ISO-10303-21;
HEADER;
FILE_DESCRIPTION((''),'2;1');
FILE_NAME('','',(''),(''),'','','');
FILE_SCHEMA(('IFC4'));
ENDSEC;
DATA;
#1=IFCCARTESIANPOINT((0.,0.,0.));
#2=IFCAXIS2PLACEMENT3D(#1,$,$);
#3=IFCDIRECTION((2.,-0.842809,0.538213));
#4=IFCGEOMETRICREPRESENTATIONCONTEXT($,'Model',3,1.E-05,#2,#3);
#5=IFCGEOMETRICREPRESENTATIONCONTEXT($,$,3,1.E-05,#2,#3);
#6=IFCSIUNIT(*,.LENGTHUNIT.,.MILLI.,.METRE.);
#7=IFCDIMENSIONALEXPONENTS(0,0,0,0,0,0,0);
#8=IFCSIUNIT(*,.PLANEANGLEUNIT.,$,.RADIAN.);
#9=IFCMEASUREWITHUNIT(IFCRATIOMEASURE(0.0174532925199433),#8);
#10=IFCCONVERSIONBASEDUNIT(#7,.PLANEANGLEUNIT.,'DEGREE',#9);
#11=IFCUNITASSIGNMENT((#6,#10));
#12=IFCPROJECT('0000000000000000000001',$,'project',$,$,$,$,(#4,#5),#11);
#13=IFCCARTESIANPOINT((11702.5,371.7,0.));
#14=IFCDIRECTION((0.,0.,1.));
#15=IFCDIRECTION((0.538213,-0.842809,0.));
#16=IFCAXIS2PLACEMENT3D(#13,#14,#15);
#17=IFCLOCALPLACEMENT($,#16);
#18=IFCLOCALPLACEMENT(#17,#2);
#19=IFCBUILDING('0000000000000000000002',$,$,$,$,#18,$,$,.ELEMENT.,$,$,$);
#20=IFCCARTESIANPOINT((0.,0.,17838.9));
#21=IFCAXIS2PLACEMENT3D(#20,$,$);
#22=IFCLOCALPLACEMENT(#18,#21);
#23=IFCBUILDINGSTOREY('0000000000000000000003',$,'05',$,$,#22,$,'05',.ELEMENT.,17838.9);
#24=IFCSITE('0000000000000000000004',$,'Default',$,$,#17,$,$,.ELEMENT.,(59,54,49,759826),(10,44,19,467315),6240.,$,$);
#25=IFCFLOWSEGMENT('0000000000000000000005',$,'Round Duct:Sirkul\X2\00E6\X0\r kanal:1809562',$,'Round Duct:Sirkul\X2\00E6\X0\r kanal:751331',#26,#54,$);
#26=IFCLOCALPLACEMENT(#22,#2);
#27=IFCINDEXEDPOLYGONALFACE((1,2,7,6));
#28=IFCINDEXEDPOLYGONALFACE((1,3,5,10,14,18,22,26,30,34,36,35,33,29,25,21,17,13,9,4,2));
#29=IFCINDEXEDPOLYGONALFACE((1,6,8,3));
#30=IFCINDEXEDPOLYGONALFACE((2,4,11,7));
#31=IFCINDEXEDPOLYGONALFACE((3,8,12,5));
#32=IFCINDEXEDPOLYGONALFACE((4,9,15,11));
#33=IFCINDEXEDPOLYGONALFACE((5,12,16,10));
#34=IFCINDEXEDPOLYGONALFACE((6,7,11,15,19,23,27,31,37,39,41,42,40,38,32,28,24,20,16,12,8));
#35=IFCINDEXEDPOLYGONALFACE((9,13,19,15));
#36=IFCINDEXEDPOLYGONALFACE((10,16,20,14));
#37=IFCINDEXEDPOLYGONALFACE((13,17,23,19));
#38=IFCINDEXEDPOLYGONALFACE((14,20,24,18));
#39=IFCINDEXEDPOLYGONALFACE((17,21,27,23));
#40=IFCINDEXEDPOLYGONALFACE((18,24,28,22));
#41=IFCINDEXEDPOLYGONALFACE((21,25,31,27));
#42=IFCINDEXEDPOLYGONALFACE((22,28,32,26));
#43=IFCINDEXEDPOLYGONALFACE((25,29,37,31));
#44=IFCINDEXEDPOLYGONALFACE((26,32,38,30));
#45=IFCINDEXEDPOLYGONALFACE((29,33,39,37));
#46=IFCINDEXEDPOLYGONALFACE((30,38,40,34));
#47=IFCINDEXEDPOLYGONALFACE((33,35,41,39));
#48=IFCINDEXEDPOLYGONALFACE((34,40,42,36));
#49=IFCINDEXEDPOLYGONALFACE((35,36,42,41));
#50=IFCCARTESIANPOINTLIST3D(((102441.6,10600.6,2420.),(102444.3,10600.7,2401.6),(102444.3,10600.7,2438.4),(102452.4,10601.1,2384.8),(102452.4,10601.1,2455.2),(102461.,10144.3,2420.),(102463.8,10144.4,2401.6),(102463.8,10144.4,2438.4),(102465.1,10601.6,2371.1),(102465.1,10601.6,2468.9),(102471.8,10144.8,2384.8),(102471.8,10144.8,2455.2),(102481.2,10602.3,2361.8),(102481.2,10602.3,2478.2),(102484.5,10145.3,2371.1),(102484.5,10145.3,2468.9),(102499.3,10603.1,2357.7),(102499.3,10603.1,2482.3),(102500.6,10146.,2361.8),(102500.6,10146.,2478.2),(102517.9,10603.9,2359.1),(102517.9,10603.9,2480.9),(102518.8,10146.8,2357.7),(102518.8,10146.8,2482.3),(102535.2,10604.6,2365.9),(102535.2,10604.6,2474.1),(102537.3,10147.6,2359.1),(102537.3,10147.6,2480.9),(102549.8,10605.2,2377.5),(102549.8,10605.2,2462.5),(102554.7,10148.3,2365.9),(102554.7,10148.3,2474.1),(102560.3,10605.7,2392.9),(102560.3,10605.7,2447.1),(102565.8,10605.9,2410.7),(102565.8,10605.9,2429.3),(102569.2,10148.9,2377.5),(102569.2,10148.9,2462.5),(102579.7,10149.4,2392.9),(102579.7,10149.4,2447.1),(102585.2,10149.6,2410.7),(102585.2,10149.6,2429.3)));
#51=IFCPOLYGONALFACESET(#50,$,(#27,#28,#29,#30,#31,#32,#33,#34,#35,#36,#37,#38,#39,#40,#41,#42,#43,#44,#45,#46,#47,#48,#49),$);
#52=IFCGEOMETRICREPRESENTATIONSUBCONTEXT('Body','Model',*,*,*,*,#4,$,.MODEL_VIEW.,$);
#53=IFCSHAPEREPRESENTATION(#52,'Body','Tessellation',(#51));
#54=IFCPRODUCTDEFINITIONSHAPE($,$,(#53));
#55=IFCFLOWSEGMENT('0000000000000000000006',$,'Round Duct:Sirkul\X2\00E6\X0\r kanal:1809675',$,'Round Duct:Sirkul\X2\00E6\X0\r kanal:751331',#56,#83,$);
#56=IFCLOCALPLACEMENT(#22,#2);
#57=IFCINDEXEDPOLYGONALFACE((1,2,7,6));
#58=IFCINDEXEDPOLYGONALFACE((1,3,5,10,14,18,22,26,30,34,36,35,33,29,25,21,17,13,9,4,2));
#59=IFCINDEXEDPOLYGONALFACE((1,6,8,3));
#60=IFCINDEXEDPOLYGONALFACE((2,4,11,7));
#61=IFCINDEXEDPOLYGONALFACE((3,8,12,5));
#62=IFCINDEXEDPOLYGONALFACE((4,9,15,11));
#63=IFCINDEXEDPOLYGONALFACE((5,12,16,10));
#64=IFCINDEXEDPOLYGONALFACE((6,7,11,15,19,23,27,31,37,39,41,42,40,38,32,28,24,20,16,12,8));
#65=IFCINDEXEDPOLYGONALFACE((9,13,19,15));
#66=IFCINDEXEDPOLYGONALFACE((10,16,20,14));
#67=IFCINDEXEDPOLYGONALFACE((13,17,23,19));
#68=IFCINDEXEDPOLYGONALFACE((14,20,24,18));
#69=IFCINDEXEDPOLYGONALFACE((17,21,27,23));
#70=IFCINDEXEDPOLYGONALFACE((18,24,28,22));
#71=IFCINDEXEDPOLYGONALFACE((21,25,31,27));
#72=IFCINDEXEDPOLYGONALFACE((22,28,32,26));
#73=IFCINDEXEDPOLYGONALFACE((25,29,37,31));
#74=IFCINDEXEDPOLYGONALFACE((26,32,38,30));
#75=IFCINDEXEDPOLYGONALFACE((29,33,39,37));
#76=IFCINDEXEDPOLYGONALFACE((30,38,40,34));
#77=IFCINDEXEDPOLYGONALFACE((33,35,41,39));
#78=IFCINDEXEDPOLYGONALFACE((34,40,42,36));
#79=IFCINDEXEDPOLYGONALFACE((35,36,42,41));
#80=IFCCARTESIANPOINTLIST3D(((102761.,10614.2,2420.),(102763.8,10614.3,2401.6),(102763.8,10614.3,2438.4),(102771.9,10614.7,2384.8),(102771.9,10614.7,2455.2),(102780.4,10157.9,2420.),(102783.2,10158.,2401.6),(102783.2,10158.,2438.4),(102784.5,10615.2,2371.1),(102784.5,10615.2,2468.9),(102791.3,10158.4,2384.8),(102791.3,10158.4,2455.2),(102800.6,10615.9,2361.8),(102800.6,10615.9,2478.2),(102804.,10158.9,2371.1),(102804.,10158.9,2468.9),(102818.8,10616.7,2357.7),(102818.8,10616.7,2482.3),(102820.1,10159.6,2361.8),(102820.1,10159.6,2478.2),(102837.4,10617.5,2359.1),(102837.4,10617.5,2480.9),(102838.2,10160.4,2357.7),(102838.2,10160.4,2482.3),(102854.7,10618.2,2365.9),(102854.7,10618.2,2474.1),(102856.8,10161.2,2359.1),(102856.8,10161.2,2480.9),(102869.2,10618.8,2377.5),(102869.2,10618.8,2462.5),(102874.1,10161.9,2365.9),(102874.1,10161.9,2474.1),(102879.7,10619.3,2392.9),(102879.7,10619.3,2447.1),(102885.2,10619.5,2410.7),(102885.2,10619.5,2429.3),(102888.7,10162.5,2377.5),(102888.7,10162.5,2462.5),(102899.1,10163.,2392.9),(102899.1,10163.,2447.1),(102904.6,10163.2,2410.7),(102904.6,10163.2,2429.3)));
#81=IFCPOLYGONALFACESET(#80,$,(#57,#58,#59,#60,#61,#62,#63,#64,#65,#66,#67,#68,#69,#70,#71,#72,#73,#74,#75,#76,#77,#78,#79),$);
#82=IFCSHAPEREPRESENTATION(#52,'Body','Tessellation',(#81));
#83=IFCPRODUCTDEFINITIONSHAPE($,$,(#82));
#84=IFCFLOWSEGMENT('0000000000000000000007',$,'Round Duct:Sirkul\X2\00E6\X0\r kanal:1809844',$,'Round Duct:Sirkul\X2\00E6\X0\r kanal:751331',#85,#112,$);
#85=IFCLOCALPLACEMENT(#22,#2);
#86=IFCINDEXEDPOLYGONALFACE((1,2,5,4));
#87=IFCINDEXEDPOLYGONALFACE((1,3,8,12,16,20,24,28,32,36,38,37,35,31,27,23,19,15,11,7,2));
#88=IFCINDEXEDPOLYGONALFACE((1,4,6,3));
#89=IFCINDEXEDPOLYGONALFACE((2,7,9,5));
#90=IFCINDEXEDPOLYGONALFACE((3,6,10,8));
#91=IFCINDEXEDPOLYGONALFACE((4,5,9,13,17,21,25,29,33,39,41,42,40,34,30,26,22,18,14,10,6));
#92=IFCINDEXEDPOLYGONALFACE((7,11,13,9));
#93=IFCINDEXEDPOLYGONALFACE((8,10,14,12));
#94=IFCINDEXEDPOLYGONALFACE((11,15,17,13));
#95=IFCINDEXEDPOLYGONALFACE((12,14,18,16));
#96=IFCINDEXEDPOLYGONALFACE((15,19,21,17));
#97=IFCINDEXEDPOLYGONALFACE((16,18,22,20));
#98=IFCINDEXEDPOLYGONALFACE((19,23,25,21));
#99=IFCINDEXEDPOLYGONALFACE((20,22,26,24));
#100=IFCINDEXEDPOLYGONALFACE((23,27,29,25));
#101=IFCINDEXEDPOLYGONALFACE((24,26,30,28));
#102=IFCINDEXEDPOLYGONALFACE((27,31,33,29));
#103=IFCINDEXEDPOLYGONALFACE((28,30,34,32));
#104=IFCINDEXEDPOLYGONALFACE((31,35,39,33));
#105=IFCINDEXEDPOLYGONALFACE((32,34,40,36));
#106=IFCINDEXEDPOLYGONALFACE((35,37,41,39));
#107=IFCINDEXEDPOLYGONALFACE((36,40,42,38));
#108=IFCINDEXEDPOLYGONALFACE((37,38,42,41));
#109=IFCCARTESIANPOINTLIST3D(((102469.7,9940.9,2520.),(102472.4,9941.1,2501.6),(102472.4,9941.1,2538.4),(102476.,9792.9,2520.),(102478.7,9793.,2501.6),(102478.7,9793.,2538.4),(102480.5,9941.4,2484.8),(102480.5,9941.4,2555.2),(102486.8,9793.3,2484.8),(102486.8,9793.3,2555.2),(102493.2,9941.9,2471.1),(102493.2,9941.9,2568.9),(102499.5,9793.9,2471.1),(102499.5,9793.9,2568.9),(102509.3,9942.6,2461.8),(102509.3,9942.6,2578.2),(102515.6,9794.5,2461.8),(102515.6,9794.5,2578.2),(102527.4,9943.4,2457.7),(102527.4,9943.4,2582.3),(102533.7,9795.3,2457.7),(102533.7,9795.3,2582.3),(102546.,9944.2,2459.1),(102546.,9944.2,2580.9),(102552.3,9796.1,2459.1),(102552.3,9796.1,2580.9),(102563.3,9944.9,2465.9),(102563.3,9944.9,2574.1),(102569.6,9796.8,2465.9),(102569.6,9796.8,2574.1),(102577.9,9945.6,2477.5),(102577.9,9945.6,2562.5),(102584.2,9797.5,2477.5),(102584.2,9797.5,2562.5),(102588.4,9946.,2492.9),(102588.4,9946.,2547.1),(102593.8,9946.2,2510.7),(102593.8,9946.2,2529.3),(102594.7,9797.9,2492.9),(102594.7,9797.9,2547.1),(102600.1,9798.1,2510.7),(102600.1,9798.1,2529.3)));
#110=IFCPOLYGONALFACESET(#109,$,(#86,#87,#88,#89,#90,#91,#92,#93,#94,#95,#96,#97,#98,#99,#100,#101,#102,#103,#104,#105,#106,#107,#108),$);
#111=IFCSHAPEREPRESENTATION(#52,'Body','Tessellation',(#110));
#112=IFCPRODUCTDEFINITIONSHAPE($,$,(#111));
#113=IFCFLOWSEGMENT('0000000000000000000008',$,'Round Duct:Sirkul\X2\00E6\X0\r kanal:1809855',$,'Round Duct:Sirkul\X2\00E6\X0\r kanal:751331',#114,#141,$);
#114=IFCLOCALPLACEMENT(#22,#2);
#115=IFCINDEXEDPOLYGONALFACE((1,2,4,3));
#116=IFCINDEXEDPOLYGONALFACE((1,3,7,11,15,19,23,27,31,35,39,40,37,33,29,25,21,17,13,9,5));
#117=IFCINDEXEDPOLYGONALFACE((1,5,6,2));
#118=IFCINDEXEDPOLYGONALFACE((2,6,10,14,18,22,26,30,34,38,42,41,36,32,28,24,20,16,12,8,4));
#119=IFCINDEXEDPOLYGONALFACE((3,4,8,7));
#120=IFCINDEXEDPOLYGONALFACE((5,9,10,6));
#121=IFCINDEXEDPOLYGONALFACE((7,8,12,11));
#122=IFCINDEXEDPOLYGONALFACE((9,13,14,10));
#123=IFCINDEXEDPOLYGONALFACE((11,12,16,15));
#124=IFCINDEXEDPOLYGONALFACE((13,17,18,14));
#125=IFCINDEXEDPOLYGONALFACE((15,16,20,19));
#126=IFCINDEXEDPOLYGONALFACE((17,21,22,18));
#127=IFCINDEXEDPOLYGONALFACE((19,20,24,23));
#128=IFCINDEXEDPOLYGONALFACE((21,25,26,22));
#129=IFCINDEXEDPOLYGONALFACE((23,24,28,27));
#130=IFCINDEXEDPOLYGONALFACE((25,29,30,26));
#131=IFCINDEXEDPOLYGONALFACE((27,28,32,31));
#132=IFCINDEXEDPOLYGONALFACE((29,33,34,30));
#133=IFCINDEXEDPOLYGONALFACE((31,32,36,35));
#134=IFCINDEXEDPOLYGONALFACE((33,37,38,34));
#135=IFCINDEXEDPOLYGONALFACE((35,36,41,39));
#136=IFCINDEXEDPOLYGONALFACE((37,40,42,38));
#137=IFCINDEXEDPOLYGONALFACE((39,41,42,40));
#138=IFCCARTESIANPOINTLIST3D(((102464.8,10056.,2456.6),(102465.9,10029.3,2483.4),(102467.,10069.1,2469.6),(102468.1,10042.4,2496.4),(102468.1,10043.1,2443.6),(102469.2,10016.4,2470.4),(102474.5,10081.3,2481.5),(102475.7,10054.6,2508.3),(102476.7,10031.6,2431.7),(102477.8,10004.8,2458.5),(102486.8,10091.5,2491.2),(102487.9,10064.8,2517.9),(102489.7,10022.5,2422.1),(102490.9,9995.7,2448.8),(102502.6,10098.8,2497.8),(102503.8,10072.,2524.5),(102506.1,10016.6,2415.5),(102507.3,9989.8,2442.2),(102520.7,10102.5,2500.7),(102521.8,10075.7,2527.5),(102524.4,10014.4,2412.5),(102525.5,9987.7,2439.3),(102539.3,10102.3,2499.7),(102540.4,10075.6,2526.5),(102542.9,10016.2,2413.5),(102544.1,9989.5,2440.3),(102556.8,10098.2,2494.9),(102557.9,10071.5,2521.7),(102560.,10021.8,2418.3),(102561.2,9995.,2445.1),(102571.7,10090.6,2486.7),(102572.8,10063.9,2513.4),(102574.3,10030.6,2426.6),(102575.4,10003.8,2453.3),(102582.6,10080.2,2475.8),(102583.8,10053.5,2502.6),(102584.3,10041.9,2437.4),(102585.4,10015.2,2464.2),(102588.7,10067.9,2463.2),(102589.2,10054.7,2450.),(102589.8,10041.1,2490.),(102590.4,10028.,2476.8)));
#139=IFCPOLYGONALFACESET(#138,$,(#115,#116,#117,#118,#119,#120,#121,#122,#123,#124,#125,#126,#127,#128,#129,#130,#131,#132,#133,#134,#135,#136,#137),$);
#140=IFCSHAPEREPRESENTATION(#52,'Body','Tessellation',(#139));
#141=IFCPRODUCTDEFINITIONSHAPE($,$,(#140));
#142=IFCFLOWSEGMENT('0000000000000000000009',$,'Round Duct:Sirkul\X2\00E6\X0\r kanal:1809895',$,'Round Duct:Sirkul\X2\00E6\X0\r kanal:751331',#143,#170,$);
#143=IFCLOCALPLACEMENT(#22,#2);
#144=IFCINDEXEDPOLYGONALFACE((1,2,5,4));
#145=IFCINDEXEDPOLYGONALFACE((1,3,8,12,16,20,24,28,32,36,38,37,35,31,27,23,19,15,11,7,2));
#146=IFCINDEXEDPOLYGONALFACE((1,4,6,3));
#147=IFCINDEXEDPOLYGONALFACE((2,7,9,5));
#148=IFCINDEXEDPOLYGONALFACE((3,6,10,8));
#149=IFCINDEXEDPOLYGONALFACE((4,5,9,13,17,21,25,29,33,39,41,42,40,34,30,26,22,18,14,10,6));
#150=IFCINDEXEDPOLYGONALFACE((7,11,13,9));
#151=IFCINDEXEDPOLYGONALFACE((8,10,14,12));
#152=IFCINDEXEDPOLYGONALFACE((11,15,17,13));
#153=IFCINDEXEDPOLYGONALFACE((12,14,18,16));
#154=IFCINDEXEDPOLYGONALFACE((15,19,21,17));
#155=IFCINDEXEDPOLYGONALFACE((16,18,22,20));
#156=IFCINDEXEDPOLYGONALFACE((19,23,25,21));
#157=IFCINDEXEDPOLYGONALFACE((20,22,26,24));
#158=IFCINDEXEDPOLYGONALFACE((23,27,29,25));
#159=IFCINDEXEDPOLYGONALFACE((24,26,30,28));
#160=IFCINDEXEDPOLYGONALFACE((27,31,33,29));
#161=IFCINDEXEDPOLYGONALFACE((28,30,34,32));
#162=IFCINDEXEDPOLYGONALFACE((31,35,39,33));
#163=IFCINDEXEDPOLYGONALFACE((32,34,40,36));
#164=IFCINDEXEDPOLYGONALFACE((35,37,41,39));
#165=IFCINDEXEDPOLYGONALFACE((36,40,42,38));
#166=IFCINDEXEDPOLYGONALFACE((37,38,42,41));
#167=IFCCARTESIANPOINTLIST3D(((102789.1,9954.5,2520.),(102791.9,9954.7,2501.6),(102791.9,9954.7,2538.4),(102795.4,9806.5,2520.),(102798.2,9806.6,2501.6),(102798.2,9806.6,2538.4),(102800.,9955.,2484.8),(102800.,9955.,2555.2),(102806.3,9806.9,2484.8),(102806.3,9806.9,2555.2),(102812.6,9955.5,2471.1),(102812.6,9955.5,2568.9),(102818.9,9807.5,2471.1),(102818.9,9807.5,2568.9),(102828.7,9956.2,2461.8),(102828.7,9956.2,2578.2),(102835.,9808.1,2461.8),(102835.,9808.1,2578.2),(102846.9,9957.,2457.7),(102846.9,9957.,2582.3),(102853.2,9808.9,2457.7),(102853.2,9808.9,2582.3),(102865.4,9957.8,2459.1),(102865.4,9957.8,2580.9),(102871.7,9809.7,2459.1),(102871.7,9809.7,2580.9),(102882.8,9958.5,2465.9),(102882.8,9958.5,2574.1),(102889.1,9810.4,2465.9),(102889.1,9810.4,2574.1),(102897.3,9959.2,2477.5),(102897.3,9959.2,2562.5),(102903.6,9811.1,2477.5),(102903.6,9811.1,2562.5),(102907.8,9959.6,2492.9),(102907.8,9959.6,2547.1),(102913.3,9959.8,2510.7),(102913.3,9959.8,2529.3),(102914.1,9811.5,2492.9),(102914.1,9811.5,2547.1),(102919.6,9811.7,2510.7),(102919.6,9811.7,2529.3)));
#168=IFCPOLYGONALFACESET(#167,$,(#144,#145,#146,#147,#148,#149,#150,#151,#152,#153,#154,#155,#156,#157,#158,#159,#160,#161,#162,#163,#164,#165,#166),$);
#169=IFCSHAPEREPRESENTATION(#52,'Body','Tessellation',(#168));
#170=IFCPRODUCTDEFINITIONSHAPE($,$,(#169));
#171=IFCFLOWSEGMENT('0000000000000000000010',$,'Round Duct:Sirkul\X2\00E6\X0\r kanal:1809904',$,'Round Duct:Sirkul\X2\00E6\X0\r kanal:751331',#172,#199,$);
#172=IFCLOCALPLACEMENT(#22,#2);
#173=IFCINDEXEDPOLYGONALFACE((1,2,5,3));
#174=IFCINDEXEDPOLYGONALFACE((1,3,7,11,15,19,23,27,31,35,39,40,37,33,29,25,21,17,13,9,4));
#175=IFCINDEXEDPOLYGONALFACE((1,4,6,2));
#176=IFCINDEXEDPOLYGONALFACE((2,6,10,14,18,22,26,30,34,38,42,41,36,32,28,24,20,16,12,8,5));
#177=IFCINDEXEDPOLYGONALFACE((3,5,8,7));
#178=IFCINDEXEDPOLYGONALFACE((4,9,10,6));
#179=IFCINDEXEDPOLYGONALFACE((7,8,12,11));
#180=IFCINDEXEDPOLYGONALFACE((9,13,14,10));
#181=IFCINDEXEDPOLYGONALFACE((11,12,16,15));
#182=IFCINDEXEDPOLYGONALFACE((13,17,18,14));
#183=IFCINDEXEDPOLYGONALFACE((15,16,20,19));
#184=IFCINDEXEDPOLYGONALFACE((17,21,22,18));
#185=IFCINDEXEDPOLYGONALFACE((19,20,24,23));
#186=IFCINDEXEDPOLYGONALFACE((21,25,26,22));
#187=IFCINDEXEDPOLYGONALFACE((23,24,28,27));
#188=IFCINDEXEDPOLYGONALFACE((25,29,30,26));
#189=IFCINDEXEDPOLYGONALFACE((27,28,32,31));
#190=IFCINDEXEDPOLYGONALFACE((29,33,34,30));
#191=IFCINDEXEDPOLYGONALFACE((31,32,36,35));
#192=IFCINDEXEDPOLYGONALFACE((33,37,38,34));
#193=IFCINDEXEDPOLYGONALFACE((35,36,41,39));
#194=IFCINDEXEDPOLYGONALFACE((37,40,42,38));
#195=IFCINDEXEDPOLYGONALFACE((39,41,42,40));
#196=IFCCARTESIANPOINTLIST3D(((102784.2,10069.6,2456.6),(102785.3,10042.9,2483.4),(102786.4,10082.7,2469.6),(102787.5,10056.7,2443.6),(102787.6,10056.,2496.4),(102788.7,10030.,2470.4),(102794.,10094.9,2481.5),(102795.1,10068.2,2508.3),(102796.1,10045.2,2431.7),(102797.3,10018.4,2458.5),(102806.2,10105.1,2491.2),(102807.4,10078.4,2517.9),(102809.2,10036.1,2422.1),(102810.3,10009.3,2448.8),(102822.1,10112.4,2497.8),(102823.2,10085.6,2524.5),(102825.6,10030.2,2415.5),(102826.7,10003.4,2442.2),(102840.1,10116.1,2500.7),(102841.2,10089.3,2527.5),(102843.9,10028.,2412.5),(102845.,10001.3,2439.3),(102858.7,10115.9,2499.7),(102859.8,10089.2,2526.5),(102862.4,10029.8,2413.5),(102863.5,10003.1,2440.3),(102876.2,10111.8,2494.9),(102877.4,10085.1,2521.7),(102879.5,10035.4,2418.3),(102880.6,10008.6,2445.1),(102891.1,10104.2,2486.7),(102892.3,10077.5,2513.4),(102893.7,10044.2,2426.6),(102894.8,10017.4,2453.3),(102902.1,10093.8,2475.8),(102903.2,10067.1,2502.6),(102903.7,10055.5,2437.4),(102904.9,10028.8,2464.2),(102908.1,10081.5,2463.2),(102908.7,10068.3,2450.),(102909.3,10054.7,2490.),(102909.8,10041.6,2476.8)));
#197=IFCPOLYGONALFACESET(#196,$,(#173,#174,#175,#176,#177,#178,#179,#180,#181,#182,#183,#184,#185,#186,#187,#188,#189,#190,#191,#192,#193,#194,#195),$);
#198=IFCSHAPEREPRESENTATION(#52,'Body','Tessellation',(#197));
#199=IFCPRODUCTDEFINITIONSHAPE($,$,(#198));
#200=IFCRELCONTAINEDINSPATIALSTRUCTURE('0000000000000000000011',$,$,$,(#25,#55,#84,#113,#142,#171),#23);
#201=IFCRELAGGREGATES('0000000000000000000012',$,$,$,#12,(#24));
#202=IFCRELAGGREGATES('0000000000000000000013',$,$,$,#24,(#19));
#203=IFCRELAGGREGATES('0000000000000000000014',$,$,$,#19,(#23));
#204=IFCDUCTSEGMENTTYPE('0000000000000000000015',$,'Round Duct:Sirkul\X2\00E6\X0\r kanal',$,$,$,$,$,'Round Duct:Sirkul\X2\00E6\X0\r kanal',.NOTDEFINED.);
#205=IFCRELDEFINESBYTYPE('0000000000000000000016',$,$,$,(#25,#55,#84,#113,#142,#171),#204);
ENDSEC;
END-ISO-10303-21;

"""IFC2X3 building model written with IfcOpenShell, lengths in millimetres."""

from ifc_helpers import new_model, entity, si_unit, converted_unit, direction, frame, frame_2d, origin, origin_2d_with_axis, place, context, subcontext, project, spatial, circle, extrude, type_object, element, save


model = new_model("IFC2X3")

# Units and contexts
model_context = context("Model", 3, precision=1e-05, world=origin(), true_north=direction((2.0, -0.842809, 0.538213)))
context_of_model = context(None, 3, precision=1e-05, world=origin(), true_north=direction((2.0, -0.842809, 0.538213)))
body_context = subcontext(model_context, "Body", "Model", "MODEL_VIEW")
ifc_project = project(units=[si_unit("LENGTHUNIT", "METRE", prefix="MILLI"), converted_unit("PLANEANGLEUNIT", "DEGREE", entity("IfcRatioMeasure", 0.0174532925199433), si_unit("PLANEANGLEUNIT", "RADIAN"), dimensions=[0, 0, 0, 0, 0, 0, 0])], contexts=[model_context, context_of_model])

# Site, building, storey
site_placement = place(None, frame((11702.5, 371.7, 0.0), z_axis=(0.0, 0.0, 1.0), x_axis=(0.538213, -0.842809, 0.0)))
site = spatial("IfcSite", under=ifc_project, at=site_placement, Name="Default", CompositionType="ELEMENT", RefLatitude=(59, 54, 49, 759826), RefLongitude=(10, 44, 19, 467315), RefElevation=6240.0)
building_placement = place(site_placement, origin())
building = spatial("IfcBuilding", under=site, at=building_placement, CompositionType="ELEMENT")
storey_placement = place(building_placement, frame((0.0, 0.0, 17838.9)))
storey = spatial("IfcBuildingStorey", under=building, at=storey_placement, Name="05", LongName="05", CompositionType="ELEMENT", Elevation=17838.9)

# Flow segments
duct_segment_type = type_object("IfcDuctSegmentType", Name="Round Duct:Sirkulær kanal", ElementType="Round Duct:Sirkulær kanal", PredefinedType="NOTDEFINED")
flow_segment_1_placement = place(storey_placement, origin())
element("IfcFlowSegment", 1, at=flow_segment_1_placement, inside=storey, type_object=duct_segment_type, Name="Round Duct:Sirkulær kanal:1809562", ObjectType="Round Duct:Sirkulær kanal:751331", context=body_context, shape_type="SweptSolid", body=[
    extrude(circle(Radius=62.5, at=origin_2d_with_axis()), frame((102504.0, 10603.3, 2420.0), z_axis=(0.042537, -0.999095, 0.0), x_axis=(-0.999095, -0.042537, 0.0)), (0.0, 0.0, 1.0), 456.7),
])
flow_segment_2_placement = place(storey_placement, origin())
element("IfcFlowSegment", 2, at=flow_segment_2_placement, inside=storey, type_object=duct_segment_type, Name="Round Duct:Sirkulær kanal:1809675", ObjectType="Round Duct:Sirkulær kanal:751331", context=body_context, shape_type="SweptSolid", body=[
    extrude(circle(Radius=62.5, at=origin_2d_with_axis()), frame((102842.9, 10160.6, 2420.0), z_axis=(-0.042537, 0.999095, 0.0), x_axis=(-0.999095, -0.042537, 0.0)), (0.0, 0.0, 1.0), 456.7),
])
flow_segment_3_placement = place(storey_placement, origin())
element("IfcFlowSegment", 3, at=flow_segment_3_placement, inside=storey, type_object=duct_segment_type, Name="Round Duct:Sirkulær kanal:1809844", ObjectType="Round Duct:Sirkulær kanal:751331", context=body_context, shape_type="SweptSolid", body=[
    extrude(circle(Radius=62.5, at=origin_2d_with_axis()), frame((102538.4, 9795.5, 2520.0), z_axis=(-0.042537, 0.999095, 0.0), x_axis=(-0.999095, -0.042537, 0.0)), (0.0, 0.0, 1.0), 148.2),
])
flow_segment_4_placement = place(storey_placement, origin())
element("IfcFlowSegment", 4, at=flow_segment_4_placement, inside=storey, type_object=duct_segment_type, Name="Round Duct:Sirkulær kanal:1809855", ObjectType="Round Duct:Sirkulær kanal:751331", context=body_context, shape_type="SweptSolid", body=[
    extrude(circle(Radius=62.5, at=frame_2d((0.0, 0.0), x_axis=(1.0, 0.0))), frame((102527.2, 10058.7, 2456.6), z_axis=(0.030078, -0.706467, 0.707107), x_axis=(-0.999095, -0.042537, 0.0)), (0.0, 0.0, 1.0), 37.9),
])
flow_segment_5_placement = place(storey_placement, origin())
element("IfcFlowSegment", 5, at=flow_segment_5_placement, inside=storey, type_object=duct_segment_type, Name="Round Duct:Sirkulær kanal:1809895", ObjectType="Round Duct:Sirkulær kanal:751331", context=body_context, shape_type="SweptSolid", body=[
    extrude(circle(Radius=62.5, at=origin_2d_with_axis()), frame((102851.5, 9957.2, 2520.0), z_axis=(0.042537, -0.999095, 0.0), x_axis=(-0.999095, -0.042537, 0.0)), (0.0, 0.0, 1.0), 148.2),
])
flow_segment_6_placement = place(storey_placement, origin())
element("IfcFlowSegment", 6, at=flow_segment_6_placement, inside=storey, type_object=duct_segment_type, Name="Round Duct:Sirkulær kanal:1809904", ObjectType="Round Duct:Sirkulær kanal:751331", context=body_context, shape_type="SweptSolid", body=[
    extrude(circle(Radius=62.5, at=frame_2d((0.0, 0.0), x_axis=(1.0, 0.0))), frame((102846.6, 10072.3, 2456.6), z_axis=(0.030078, -0.706467, 0.707107), x_axis=(-0.999095, -0.042537, 0.0)), (0.0, 0.0, 1.0), 37.9),
])

save(model, "model.ifc")
